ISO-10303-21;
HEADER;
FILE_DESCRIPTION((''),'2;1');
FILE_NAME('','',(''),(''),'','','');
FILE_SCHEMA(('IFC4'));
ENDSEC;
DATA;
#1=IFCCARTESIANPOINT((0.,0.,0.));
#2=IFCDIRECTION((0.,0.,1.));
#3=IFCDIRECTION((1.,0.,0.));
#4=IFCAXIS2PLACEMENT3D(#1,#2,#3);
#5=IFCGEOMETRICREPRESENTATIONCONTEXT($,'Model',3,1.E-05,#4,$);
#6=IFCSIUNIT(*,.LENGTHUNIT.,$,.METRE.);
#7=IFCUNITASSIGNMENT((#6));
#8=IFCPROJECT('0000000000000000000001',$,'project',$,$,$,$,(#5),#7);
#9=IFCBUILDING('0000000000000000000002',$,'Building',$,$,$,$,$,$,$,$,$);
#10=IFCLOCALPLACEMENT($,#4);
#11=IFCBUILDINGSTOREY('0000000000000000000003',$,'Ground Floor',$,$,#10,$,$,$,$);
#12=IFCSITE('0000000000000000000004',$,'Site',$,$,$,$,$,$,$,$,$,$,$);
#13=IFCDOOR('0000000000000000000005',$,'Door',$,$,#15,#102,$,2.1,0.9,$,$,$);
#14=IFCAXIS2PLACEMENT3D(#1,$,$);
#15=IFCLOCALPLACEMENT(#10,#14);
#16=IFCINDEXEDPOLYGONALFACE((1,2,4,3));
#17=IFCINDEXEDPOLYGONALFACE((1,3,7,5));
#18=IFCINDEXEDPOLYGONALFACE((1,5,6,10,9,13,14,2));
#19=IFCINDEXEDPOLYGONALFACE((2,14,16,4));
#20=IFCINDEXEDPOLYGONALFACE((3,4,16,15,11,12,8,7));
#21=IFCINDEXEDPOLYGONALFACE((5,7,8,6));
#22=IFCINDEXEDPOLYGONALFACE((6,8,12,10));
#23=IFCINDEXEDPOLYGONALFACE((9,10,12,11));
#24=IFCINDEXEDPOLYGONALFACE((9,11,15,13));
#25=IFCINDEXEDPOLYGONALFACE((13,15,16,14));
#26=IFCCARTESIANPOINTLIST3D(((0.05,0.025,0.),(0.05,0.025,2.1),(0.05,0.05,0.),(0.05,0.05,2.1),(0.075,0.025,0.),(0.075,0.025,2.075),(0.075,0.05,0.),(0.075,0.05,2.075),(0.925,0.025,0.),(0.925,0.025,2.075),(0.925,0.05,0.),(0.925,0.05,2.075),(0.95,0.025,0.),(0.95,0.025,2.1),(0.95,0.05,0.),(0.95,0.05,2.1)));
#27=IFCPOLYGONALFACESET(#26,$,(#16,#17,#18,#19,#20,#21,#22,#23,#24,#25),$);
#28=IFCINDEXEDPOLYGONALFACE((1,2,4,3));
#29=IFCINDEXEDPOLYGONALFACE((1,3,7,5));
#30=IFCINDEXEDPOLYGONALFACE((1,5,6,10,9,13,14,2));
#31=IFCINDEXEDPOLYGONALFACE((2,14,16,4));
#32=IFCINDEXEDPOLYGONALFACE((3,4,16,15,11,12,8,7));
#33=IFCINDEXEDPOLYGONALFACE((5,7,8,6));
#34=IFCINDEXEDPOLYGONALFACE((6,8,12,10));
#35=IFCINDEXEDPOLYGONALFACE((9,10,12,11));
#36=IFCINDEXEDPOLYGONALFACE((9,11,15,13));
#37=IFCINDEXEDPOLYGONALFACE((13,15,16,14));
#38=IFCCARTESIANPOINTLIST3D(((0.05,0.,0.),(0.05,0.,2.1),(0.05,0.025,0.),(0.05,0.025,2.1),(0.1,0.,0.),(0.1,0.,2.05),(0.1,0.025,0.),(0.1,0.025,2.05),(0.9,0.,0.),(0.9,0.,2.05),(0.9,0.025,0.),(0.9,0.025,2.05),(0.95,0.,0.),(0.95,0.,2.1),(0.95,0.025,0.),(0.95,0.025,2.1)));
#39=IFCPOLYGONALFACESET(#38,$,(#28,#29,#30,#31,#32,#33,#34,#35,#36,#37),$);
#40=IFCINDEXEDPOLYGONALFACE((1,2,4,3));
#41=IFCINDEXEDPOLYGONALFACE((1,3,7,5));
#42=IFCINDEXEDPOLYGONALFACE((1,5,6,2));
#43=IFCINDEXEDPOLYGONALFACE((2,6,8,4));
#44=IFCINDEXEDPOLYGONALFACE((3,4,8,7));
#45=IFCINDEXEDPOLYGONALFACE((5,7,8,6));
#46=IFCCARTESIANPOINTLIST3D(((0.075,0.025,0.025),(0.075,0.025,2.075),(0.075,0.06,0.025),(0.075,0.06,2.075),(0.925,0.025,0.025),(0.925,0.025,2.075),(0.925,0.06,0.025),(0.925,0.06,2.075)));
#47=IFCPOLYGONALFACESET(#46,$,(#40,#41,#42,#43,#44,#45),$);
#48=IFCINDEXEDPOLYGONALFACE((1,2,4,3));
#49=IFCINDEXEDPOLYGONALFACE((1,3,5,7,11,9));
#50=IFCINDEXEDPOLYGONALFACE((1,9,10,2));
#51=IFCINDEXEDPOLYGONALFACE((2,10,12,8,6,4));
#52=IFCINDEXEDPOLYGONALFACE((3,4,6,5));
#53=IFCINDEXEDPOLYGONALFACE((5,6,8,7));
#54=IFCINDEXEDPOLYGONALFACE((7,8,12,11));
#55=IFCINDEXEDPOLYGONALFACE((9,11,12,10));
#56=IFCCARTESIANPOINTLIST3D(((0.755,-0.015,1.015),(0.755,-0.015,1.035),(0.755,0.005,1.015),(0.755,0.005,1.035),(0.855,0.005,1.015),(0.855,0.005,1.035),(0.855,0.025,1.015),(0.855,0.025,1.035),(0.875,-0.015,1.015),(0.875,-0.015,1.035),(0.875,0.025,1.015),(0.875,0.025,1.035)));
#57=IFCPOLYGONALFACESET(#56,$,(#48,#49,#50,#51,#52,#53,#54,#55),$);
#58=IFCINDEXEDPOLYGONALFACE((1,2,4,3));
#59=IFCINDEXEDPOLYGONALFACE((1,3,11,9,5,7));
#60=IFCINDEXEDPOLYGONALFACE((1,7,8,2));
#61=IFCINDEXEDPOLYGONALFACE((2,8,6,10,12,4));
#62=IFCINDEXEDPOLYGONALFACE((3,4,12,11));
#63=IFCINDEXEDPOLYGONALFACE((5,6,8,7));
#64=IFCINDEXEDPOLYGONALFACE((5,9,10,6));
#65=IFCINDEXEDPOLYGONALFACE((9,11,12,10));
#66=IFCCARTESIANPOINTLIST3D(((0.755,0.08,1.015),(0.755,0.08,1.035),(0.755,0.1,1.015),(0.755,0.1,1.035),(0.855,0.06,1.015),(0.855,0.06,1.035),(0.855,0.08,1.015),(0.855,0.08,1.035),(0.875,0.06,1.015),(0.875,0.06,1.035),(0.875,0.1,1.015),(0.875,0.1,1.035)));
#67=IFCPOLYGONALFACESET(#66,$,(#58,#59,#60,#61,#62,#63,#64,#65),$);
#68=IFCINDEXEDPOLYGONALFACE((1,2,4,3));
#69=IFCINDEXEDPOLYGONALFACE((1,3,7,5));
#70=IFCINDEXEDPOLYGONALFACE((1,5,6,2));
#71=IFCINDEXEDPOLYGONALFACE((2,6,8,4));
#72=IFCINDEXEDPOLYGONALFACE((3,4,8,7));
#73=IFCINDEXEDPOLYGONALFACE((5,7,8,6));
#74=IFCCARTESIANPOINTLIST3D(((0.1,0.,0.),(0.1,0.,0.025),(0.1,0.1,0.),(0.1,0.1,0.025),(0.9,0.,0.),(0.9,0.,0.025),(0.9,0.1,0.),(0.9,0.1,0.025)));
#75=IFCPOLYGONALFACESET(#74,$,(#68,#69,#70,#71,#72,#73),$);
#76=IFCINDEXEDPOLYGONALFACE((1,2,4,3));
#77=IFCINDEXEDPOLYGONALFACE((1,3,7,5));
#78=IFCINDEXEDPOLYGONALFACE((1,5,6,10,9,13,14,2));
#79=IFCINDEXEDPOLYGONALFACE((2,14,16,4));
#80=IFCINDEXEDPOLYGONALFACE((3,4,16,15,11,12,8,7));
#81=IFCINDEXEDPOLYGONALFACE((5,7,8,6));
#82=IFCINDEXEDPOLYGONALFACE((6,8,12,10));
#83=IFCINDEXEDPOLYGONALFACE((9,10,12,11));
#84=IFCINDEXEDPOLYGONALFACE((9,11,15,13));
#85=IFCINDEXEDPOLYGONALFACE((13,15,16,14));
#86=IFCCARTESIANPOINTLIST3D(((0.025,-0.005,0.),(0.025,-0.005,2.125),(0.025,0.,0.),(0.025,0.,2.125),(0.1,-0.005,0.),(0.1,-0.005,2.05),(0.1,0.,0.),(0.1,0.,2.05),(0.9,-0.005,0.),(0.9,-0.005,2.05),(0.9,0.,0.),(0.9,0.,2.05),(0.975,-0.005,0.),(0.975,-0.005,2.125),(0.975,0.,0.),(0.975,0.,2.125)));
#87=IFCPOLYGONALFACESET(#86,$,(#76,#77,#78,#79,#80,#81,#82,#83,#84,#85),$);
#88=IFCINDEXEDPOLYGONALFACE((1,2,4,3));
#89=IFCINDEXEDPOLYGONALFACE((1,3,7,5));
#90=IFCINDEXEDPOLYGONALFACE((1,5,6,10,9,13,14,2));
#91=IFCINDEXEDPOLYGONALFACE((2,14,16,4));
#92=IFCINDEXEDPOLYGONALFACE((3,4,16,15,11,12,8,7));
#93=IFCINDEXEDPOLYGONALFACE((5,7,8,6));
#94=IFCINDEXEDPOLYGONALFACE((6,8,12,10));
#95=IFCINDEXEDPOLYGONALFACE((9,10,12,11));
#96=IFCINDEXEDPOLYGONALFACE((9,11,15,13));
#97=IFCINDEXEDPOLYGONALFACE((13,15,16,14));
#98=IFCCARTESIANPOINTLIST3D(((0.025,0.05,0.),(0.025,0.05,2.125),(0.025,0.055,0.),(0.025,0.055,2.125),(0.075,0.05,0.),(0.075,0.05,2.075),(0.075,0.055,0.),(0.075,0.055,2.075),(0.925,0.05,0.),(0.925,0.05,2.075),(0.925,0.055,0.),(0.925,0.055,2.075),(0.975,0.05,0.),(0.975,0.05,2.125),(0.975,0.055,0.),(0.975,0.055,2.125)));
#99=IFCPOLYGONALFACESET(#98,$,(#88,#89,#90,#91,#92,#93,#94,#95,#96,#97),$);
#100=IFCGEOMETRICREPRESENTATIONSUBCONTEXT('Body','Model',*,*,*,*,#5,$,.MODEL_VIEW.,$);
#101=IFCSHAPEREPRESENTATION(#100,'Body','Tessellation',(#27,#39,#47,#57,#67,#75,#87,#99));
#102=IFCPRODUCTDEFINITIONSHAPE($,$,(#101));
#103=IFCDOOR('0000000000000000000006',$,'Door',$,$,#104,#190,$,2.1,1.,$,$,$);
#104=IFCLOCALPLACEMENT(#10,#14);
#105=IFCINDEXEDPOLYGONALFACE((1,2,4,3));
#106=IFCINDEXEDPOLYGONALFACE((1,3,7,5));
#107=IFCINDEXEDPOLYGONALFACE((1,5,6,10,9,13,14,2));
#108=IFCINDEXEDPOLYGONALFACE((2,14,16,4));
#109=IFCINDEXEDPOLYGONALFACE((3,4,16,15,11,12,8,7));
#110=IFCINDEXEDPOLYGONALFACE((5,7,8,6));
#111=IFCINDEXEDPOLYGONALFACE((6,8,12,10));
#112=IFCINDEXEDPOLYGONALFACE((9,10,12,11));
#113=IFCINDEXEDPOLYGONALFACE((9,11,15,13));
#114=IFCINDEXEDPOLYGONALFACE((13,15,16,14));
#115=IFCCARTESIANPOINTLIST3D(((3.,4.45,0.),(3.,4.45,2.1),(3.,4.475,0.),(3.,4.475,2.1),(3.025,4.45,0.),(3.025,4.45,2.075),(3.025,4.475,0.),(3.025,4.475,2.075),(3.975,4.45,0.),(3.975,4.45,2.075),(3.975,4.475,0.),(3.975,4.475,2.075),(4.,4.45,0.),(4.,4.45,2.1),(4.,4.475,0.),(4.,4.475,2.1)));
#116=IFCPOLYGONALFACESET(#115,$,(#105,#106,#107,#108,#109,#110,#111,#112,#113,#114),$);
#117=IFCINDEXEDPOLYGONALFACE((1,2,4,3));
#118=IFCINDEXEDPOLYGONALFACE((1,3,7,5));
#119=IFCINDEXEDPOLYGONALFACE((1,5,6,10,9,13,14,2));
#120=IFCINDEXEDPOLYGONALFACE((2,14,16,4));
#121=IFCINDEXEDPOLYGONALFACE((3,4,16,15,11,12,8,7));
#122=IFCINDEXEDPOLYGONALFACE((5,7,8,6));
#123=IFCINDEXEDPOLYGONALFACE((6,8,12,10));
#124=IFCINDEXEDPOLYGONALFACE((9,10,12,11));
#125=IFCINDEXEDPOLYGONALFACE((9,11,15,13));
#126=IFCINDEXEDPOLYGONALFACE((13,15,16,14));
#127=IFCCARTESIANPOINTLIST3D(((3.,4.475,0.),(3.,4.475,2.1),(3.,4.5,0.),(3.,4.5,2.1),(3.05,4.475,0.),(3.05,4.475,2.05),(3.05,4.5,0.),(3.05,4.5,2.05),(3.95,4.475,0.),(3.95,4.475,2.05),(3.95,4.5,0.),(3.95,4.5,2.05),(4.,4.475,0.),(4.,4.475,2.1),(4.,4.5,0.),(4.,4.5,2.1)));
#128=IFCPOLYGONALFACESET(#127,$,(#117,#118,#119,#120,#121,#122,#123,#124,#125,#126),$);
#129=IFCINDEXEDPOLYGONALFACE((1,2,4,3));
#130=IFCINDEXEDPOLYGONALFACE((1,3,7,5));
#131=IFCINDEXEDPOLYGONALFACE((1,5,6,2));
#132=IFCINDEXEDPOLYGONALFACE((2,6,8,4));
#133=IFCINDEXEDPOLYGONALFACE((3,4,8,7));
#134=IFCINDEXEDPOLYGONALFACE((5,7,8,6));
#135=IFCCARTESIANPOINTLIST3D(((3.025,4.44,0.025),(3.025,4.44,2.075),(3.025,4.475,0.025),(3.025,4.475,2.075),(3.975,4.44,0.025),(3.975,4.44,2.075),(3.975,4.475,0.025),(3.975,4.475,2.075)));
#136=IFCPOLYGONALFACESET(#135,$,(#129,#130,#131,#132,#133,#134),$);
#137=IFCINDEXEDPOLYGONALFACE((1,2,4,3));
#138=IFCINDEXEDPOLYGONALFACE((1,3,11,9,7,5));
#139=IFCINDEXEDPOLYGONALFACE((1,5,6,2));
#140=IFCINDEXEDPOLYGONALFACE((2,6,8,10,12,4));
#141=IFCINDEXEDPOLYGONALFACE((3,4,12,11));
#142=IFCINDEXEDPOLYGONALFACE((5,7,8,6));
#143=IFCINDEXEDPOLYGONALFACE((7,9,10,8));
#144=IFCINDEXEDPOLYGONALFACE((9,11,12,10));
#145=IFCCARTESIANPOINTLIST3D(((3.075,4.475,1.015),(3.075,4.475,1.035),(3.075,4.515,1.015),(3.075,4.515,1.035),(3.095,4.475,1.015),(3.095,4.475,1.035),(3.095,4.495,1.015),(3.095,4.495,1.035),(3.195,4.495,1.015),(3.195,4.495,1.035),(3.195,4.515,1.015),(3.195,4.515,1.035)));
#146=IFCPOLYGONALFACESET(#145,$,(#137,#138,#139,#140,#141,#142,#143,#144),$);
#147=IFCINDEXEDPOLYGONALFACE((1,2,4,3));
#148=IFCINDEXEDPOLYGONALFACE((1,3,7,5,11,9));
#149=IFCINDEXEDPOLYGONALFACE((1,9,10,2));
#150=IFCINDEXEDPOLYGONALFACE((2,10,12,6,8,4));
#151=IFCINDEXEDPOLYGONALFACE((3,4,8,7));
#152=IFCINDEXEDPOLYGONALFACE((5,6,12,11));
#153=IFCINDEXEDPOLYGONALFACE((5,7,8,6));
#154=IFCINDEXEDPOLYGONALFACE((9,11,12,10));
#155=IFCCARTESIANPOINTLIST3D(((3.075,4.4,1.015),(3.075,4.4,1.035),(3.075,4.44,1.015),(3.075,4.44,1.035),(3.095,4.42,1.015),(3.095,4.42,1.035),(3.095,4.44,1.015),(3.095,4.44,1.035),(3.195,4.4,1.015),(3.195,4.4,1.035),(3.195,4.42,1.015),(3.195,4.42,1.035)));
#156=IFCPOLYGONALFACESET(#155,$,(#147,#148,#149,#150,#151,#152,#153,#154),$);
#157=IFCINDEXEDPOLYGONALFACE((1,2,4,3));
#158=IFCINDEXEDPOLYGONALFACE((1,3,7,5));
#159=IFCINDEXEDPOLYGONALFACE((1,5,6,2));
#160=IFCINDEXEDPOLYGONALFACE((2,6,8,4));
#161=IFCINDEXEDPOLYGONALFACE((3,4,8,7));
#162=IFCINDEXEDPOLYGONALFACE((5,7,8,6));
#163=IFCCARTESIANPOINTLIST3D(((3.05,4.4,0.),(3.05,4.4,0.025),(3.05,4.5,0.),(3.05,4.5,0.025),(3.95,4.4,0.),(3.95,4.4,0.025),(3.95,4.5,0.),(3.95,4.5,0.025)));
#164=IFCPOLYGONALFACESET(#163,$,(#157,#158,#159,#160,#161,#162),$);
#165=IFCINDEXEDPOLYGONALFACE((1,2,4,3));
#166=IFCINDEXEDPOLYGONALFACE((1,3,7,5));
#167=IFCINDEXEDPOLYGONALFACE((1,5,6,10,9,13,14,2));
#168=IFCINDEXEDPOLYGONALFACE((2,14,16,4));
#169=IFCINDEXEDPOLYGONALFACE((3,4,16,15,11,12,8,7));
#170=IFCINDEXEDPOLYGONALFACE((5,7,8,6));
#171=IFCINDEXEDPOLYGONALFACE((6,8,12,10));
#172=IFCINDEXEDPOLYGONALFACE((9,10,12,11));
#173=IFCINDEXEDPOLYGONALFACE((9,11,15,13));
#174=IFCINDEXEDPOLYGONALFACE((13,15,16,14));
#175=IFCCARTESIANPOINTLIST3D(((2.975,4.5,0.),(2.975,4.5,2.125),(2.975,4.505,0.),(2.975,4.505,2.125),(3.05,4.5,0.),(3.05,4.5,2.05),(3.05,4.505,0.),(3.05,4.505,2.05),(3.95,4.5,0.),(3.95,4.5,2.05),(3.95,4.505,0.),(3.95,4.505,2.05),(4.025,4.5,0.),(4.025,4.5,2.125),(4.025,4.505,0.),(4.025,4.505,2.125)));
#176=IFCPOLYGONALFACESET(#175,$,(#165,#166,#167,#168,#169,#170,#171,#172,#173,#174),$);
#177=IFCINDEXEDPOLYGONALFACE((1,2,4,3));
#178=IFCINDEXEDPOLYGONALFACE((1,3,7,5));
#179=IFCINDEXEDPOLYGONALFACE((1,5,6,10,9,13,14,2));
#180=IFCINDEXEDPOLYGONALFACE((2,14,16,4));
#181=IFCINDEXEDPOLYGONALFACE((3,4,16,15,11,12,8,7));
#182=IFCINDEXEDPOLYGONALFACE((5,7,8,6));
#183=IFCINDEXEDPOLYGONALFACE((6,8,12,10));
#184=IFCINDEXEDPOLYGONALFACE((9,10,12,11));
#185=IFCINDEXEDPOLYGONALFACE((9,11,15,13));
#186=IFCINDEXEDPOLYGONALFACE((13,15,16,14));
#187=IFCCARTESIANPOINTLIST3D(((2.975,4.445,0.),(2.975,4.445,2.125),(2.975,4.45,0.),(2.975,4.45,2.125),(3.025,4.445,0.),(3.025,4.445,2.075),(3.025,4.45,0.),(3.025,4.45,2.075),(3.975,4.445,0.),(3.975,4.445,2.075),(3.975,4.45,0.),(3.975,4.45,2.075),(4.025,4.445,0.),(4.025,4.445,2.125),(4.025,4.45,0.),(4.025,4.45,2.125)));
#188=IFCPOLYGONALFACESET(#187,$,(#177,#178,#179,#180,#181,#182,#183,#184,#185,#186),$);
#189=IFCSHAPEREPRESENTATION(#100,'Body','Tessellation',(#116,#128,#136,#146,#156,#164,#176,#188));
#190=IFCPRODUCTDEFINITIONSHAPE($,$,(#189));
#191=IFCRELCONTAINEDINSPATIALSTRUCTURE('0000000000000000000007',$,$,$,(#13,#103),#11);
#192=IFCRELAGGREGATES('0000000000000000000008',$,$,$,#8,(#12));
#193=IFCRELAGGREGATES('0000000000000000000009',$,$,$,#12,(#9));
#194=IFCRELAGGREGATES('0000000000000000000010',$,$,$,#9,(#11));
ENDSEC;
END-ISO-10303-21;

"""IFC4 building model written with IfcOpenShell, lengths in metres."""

from ifc_helpers import new_model, si_unit, frame, origin_with_axes, place, context, subcontext, project, spatial, line, indexed_curve, outline, extrude, element, save


model = new_model("IFC4")

# Units and contexts
model_context = context("Model", 3, precision=1e-05, world=origin_with_axes())
body_context = subcontext(model_context, "Body", "Model", "MODEL_VIEW")
ifc_project = project(units=[si_unit("LENGTHUNIT", "METRE")], contexts=[model_context])

# Site, building, storey
site = spatial("IfcSite", under=ifc_project, Name="Site")
building = spatial("IfcBuilding", under=site, Name="Building")
storey_placement = place(None, origin_with_axes())
storey = spatial("IfcBuildingStorey", under=building, at=storey_placement, Name="Ground Floor")

# Doors
door_1_placement = place(storey_placement, frame((0.05, 0.0, 0.0), z_axis=(0.0, 0.0, 1.0), x_axis=(1.0, 0.0, 0.0)))
element("IfcDoor", 1, at=door_1_placement, inside=storey, Name="Door", OverallHeight=2.1, OverallWidth=0.9, context=body_context, shape_type="SweptSolid", body=[
    extrude(outline(indexed_curve([(0.0, 0.0), (0.0, 2.1), (0.9, 2.1), (0.9, 0.0), (0.875, 0.0), (0.875, 2.075), (0.025, 2.075), (0.025, 0.0)], segments=[line(1, 2, 3, 4, 5, 6, 7, 8, 1)])), frame((0.0, 0.025, 0.0), z_axis=(0.0, -1.0, 0.0), x_axis=(1.0, 0.0, 0.0)), (0.0, 0.0, -1.0), 0.025),
    extrude(outline(indexed_curve([(0.0, 0.0), (0.0, 2.1), (0.9, 2.1), (0.9, 0.0), (0.85, 0.0), (0.85, 2.05), (0.05, 2.05), (0.05, 0.0)], segments=[line(1, 2, 3, 4, 5, 6, 7, 8, 1)])), frame((0.0, 0.0, 0.0), z_axis=(0.0, -1.0, 0.0), x_axis=(1.0, 0.0, 0.0)), (0.0, 0.0, -1.0), 0.025),
    extrude(outline(indexed_curve([(0.0, 0.0), (0.85, 0.0), (0.85, 0.035), (0.0, 0.035)], segments=[line(1, 2, 3, 4, 1)])), frame((0.025, 0.025, 0.025), z_axis=(0.0, 0.0, 1.0), x_axis=(1.0, 0.0, 0.0)), (0.0, 0.0, 1.0), 2.05),
    extrude(outline(indexed_curve([(0.0, 0.0), (0.0, -0.04), (-0.12, -0.04), (-0.12, -0.02), (-0.02, -0.02), (-0.02, 0.0)], segments=[line(1, 2, 3, 4, 5, 6, 1)])), frame((0.825, 0.025, 1.015), z_axis=(0.0, 0.0, 1.0), x_axis=(1.0, 0.0, 0.0)), (0.0, 0.0, 1.0), 0.02),
    extrude(outline(indexed_curve([(0.0, 0.0), (0.0, 0.04), (-0.12, 0.04), (-0.12, 0.02), (-0.02, 0.02), (-0.02, 0.0)], segments=[line(1, 2, 3, 4, 5, 6, 1)])), frame((0.825, 0.06, 1.015), z_axis=(0.0, 0.0, 1.0), x_axis=(1.0, 0.0, 0.0)), (0.0, 0.0, 1.0), 0.02),
    extrude(outline(indexed_curve([(0.0, 0.0), (0.8, 0.0), (0.8, 0.1), (0.0, 0.1)], segments=[line(1, 2, 3, 4, 1)])), frame((0.05, 0.0, 0.0), z_axis=(0.0, 0.0, 1.0), x_axis=(1.0, 0.0, 0.0)), (0.0, 0.0, 1.0), 0.025),
    extrude(outline(indexed_curve([(0.0, 0.0), (0.0, 2.125), (0.95, 2.125), (0.95, 0.0), (0.875, 0.0), (0.875, 2.05), (0.075, 2.05), (0.075, 0.0)], segments=[line(1, 2, 3, 4, 5, 6, 7, 8, 1)])), frame((-0.025, -0.005, 0.0), z_axis=(0.0, -1.0, 0.0), x_axis=(1.0, 0.0, 0.0)), (0.0, 0.0, -1.0), 0.005),
    extrude(outline(indexed_curve([(0.0, 0.0), (0.0, 2.125), (0.95, 2.125), (0.95, 0.0), (0.9, 0.0), (0.9, 2.075), (0.05, 2.075), (0.05, 0.0)], segments=[line(1, 2, 3, 4, 5, 6, 7, 8, 1)])), frame((-0.025, 0.05, 0.0), z_axis=(0.0, -1.0, 0.0), x_axis=(1.0, 0.0, 0.0)), (0.0, 0.0, -1.0), 0.005),
])
door_2_placement = place(storey_placement, frame((4.0, 4.5, 0.0), z_axis=(0.0, 0.0, 1.0), x_axis=(-1.0, 0.0, 0.0)))
element("IfcDoor", 2, at=door_2_placement, inside=storey, Name="Door", OverallHeight=2.1, OverallWidth=1.0, context=body_context, shape_type="SweptSolid", body=[
    extrude(outline(indexed_curve([(0.0, 0.0), (0.0, 2.1), (1.0, 2.1), (1.0, 0.0), (0.975, 0.0), (0.975, 2.075), (0.025, 2.075), (0.025, 0.0)], segments=[line(1, 2, 3, 4, 5, 6, 7, 8, 1)])), frame((0.0, 0.025, 0.0), z_axis=(0.0, -1.0, 0.0), x_axis=(1.0, 0.0, 0.0)), (0.0, 0.0, -1.0), 0.025),
    extrude(outline(indexed_curve([(0.0, 0.0), (0.0, 2.1), (1.0, 2.1), (1.0, 0.0), (0.95, 0.0), (0.95, 2.05), (0.05, 2.05), (0.05, 0.0)], segments=[line(1, 2, 3, 4, 5, 6, 7, 8, 1)])), frame((0.0, 0.0, 0.0), z_axis=(0.0, -1.0, 0.0), x_axis=(1.0, 0.0, 0.0)), (0.0, 0.0, -1.0), 0.025),
    extrude(outline(indexed_curve([(0.0, 0.0), (0.95, 0.0), (0.95, 0.035), (0.0, 0.035)], segments=[line(1, 2, 3, 4, 1)])), frame((0.025, 0.025, 0.025), z_axis=(0.0, 0.0, 1.0), x_axis=(1.0, 0.0, 0.0)), (0.0, 0.0, 1.0), 2.05),
    extrude(outline(indexed_curve([(0.0, 0.0), (0.0, -0.04), (-0.12, -0.04), (-0.12, -0.02), (-0.02, -0.02), (-0.02, 0.0)], segments=[line(1, 2, 3, 4, 5, 6, 1)])), frame((0.925, 0.025, 1.015), z_axis=(0.0, 0.0, 1.0), x_axis=(1.0, 0.0, 0.0)), (0.0, 0.0, 1.0), 0.02),
    extrude(outline(indexed_curve([(0.0, 0.0), (0.0, 0.04), (-0.12, 0.04), (-0.12, 0.02), (-0.02, 0.02), (-0.02, 0.0)], segments=[line(1, 2, 3, 4, 5, 6, 1)])), frame((0.925, 0.06, 1.015), z_axis=(0.0, 0.0, 1.0), x_axis=(1.0, 0.0, 0.0)), (0.0, 0.0, 1.0), 0.02),
    extrude(outline(indexed_curve([(0.0, 0.0), (0.9, 0.0), (0.9, 0.1), (0.0, 0.1)], segments=[line(1, 2, 3, 4, 1)])), frame((0.05, 0.0, 0.0), z_axis=(0.0, 0.0, 1.0), x_axis=(1.0, 0.0, 0.0)), (0.0, 0.0, 1.0), 0.025),
    extrude(outline(indexed_curve([(0.0, 0.0), (0.0, 2.125), (1.05, 2.125), (1.05, 0.0), (0.975, 0.0), (0.975, 2.05), (0.075, 2.05), (0.075, 0.0)], segments=[line(1, 2, 3, 4, 5, 6, 7, 8, 1)])), frame((-0.025, -0.005, 0.0), z_axis=(0.0, -1.0, 0.0), x_axis=(1.0, 0.0, 0.0)), (0.0, 0.0, -1.0), 0.005),
    extrude(outline(indexed_curve([(0.0, 0.0), (0.0, 2.125), (1.05, 2.125), (1.05, 0.0), (1.0, 0.0), (1.0, 2.075), (0.05, 2.075), (0.05, 0.0)], segments=[line(1, 2, 3, 4, 5, 6, 7, 8, 1)])), frame((-0.025, 0.05, 0.0), z_axis=(0.0, -1.0, 0.0), x_axis=(1.0, 0.0, 0.0)), (0.0, 0.0, -1.0), 0.005),
])

save(model, "model.ifc")
